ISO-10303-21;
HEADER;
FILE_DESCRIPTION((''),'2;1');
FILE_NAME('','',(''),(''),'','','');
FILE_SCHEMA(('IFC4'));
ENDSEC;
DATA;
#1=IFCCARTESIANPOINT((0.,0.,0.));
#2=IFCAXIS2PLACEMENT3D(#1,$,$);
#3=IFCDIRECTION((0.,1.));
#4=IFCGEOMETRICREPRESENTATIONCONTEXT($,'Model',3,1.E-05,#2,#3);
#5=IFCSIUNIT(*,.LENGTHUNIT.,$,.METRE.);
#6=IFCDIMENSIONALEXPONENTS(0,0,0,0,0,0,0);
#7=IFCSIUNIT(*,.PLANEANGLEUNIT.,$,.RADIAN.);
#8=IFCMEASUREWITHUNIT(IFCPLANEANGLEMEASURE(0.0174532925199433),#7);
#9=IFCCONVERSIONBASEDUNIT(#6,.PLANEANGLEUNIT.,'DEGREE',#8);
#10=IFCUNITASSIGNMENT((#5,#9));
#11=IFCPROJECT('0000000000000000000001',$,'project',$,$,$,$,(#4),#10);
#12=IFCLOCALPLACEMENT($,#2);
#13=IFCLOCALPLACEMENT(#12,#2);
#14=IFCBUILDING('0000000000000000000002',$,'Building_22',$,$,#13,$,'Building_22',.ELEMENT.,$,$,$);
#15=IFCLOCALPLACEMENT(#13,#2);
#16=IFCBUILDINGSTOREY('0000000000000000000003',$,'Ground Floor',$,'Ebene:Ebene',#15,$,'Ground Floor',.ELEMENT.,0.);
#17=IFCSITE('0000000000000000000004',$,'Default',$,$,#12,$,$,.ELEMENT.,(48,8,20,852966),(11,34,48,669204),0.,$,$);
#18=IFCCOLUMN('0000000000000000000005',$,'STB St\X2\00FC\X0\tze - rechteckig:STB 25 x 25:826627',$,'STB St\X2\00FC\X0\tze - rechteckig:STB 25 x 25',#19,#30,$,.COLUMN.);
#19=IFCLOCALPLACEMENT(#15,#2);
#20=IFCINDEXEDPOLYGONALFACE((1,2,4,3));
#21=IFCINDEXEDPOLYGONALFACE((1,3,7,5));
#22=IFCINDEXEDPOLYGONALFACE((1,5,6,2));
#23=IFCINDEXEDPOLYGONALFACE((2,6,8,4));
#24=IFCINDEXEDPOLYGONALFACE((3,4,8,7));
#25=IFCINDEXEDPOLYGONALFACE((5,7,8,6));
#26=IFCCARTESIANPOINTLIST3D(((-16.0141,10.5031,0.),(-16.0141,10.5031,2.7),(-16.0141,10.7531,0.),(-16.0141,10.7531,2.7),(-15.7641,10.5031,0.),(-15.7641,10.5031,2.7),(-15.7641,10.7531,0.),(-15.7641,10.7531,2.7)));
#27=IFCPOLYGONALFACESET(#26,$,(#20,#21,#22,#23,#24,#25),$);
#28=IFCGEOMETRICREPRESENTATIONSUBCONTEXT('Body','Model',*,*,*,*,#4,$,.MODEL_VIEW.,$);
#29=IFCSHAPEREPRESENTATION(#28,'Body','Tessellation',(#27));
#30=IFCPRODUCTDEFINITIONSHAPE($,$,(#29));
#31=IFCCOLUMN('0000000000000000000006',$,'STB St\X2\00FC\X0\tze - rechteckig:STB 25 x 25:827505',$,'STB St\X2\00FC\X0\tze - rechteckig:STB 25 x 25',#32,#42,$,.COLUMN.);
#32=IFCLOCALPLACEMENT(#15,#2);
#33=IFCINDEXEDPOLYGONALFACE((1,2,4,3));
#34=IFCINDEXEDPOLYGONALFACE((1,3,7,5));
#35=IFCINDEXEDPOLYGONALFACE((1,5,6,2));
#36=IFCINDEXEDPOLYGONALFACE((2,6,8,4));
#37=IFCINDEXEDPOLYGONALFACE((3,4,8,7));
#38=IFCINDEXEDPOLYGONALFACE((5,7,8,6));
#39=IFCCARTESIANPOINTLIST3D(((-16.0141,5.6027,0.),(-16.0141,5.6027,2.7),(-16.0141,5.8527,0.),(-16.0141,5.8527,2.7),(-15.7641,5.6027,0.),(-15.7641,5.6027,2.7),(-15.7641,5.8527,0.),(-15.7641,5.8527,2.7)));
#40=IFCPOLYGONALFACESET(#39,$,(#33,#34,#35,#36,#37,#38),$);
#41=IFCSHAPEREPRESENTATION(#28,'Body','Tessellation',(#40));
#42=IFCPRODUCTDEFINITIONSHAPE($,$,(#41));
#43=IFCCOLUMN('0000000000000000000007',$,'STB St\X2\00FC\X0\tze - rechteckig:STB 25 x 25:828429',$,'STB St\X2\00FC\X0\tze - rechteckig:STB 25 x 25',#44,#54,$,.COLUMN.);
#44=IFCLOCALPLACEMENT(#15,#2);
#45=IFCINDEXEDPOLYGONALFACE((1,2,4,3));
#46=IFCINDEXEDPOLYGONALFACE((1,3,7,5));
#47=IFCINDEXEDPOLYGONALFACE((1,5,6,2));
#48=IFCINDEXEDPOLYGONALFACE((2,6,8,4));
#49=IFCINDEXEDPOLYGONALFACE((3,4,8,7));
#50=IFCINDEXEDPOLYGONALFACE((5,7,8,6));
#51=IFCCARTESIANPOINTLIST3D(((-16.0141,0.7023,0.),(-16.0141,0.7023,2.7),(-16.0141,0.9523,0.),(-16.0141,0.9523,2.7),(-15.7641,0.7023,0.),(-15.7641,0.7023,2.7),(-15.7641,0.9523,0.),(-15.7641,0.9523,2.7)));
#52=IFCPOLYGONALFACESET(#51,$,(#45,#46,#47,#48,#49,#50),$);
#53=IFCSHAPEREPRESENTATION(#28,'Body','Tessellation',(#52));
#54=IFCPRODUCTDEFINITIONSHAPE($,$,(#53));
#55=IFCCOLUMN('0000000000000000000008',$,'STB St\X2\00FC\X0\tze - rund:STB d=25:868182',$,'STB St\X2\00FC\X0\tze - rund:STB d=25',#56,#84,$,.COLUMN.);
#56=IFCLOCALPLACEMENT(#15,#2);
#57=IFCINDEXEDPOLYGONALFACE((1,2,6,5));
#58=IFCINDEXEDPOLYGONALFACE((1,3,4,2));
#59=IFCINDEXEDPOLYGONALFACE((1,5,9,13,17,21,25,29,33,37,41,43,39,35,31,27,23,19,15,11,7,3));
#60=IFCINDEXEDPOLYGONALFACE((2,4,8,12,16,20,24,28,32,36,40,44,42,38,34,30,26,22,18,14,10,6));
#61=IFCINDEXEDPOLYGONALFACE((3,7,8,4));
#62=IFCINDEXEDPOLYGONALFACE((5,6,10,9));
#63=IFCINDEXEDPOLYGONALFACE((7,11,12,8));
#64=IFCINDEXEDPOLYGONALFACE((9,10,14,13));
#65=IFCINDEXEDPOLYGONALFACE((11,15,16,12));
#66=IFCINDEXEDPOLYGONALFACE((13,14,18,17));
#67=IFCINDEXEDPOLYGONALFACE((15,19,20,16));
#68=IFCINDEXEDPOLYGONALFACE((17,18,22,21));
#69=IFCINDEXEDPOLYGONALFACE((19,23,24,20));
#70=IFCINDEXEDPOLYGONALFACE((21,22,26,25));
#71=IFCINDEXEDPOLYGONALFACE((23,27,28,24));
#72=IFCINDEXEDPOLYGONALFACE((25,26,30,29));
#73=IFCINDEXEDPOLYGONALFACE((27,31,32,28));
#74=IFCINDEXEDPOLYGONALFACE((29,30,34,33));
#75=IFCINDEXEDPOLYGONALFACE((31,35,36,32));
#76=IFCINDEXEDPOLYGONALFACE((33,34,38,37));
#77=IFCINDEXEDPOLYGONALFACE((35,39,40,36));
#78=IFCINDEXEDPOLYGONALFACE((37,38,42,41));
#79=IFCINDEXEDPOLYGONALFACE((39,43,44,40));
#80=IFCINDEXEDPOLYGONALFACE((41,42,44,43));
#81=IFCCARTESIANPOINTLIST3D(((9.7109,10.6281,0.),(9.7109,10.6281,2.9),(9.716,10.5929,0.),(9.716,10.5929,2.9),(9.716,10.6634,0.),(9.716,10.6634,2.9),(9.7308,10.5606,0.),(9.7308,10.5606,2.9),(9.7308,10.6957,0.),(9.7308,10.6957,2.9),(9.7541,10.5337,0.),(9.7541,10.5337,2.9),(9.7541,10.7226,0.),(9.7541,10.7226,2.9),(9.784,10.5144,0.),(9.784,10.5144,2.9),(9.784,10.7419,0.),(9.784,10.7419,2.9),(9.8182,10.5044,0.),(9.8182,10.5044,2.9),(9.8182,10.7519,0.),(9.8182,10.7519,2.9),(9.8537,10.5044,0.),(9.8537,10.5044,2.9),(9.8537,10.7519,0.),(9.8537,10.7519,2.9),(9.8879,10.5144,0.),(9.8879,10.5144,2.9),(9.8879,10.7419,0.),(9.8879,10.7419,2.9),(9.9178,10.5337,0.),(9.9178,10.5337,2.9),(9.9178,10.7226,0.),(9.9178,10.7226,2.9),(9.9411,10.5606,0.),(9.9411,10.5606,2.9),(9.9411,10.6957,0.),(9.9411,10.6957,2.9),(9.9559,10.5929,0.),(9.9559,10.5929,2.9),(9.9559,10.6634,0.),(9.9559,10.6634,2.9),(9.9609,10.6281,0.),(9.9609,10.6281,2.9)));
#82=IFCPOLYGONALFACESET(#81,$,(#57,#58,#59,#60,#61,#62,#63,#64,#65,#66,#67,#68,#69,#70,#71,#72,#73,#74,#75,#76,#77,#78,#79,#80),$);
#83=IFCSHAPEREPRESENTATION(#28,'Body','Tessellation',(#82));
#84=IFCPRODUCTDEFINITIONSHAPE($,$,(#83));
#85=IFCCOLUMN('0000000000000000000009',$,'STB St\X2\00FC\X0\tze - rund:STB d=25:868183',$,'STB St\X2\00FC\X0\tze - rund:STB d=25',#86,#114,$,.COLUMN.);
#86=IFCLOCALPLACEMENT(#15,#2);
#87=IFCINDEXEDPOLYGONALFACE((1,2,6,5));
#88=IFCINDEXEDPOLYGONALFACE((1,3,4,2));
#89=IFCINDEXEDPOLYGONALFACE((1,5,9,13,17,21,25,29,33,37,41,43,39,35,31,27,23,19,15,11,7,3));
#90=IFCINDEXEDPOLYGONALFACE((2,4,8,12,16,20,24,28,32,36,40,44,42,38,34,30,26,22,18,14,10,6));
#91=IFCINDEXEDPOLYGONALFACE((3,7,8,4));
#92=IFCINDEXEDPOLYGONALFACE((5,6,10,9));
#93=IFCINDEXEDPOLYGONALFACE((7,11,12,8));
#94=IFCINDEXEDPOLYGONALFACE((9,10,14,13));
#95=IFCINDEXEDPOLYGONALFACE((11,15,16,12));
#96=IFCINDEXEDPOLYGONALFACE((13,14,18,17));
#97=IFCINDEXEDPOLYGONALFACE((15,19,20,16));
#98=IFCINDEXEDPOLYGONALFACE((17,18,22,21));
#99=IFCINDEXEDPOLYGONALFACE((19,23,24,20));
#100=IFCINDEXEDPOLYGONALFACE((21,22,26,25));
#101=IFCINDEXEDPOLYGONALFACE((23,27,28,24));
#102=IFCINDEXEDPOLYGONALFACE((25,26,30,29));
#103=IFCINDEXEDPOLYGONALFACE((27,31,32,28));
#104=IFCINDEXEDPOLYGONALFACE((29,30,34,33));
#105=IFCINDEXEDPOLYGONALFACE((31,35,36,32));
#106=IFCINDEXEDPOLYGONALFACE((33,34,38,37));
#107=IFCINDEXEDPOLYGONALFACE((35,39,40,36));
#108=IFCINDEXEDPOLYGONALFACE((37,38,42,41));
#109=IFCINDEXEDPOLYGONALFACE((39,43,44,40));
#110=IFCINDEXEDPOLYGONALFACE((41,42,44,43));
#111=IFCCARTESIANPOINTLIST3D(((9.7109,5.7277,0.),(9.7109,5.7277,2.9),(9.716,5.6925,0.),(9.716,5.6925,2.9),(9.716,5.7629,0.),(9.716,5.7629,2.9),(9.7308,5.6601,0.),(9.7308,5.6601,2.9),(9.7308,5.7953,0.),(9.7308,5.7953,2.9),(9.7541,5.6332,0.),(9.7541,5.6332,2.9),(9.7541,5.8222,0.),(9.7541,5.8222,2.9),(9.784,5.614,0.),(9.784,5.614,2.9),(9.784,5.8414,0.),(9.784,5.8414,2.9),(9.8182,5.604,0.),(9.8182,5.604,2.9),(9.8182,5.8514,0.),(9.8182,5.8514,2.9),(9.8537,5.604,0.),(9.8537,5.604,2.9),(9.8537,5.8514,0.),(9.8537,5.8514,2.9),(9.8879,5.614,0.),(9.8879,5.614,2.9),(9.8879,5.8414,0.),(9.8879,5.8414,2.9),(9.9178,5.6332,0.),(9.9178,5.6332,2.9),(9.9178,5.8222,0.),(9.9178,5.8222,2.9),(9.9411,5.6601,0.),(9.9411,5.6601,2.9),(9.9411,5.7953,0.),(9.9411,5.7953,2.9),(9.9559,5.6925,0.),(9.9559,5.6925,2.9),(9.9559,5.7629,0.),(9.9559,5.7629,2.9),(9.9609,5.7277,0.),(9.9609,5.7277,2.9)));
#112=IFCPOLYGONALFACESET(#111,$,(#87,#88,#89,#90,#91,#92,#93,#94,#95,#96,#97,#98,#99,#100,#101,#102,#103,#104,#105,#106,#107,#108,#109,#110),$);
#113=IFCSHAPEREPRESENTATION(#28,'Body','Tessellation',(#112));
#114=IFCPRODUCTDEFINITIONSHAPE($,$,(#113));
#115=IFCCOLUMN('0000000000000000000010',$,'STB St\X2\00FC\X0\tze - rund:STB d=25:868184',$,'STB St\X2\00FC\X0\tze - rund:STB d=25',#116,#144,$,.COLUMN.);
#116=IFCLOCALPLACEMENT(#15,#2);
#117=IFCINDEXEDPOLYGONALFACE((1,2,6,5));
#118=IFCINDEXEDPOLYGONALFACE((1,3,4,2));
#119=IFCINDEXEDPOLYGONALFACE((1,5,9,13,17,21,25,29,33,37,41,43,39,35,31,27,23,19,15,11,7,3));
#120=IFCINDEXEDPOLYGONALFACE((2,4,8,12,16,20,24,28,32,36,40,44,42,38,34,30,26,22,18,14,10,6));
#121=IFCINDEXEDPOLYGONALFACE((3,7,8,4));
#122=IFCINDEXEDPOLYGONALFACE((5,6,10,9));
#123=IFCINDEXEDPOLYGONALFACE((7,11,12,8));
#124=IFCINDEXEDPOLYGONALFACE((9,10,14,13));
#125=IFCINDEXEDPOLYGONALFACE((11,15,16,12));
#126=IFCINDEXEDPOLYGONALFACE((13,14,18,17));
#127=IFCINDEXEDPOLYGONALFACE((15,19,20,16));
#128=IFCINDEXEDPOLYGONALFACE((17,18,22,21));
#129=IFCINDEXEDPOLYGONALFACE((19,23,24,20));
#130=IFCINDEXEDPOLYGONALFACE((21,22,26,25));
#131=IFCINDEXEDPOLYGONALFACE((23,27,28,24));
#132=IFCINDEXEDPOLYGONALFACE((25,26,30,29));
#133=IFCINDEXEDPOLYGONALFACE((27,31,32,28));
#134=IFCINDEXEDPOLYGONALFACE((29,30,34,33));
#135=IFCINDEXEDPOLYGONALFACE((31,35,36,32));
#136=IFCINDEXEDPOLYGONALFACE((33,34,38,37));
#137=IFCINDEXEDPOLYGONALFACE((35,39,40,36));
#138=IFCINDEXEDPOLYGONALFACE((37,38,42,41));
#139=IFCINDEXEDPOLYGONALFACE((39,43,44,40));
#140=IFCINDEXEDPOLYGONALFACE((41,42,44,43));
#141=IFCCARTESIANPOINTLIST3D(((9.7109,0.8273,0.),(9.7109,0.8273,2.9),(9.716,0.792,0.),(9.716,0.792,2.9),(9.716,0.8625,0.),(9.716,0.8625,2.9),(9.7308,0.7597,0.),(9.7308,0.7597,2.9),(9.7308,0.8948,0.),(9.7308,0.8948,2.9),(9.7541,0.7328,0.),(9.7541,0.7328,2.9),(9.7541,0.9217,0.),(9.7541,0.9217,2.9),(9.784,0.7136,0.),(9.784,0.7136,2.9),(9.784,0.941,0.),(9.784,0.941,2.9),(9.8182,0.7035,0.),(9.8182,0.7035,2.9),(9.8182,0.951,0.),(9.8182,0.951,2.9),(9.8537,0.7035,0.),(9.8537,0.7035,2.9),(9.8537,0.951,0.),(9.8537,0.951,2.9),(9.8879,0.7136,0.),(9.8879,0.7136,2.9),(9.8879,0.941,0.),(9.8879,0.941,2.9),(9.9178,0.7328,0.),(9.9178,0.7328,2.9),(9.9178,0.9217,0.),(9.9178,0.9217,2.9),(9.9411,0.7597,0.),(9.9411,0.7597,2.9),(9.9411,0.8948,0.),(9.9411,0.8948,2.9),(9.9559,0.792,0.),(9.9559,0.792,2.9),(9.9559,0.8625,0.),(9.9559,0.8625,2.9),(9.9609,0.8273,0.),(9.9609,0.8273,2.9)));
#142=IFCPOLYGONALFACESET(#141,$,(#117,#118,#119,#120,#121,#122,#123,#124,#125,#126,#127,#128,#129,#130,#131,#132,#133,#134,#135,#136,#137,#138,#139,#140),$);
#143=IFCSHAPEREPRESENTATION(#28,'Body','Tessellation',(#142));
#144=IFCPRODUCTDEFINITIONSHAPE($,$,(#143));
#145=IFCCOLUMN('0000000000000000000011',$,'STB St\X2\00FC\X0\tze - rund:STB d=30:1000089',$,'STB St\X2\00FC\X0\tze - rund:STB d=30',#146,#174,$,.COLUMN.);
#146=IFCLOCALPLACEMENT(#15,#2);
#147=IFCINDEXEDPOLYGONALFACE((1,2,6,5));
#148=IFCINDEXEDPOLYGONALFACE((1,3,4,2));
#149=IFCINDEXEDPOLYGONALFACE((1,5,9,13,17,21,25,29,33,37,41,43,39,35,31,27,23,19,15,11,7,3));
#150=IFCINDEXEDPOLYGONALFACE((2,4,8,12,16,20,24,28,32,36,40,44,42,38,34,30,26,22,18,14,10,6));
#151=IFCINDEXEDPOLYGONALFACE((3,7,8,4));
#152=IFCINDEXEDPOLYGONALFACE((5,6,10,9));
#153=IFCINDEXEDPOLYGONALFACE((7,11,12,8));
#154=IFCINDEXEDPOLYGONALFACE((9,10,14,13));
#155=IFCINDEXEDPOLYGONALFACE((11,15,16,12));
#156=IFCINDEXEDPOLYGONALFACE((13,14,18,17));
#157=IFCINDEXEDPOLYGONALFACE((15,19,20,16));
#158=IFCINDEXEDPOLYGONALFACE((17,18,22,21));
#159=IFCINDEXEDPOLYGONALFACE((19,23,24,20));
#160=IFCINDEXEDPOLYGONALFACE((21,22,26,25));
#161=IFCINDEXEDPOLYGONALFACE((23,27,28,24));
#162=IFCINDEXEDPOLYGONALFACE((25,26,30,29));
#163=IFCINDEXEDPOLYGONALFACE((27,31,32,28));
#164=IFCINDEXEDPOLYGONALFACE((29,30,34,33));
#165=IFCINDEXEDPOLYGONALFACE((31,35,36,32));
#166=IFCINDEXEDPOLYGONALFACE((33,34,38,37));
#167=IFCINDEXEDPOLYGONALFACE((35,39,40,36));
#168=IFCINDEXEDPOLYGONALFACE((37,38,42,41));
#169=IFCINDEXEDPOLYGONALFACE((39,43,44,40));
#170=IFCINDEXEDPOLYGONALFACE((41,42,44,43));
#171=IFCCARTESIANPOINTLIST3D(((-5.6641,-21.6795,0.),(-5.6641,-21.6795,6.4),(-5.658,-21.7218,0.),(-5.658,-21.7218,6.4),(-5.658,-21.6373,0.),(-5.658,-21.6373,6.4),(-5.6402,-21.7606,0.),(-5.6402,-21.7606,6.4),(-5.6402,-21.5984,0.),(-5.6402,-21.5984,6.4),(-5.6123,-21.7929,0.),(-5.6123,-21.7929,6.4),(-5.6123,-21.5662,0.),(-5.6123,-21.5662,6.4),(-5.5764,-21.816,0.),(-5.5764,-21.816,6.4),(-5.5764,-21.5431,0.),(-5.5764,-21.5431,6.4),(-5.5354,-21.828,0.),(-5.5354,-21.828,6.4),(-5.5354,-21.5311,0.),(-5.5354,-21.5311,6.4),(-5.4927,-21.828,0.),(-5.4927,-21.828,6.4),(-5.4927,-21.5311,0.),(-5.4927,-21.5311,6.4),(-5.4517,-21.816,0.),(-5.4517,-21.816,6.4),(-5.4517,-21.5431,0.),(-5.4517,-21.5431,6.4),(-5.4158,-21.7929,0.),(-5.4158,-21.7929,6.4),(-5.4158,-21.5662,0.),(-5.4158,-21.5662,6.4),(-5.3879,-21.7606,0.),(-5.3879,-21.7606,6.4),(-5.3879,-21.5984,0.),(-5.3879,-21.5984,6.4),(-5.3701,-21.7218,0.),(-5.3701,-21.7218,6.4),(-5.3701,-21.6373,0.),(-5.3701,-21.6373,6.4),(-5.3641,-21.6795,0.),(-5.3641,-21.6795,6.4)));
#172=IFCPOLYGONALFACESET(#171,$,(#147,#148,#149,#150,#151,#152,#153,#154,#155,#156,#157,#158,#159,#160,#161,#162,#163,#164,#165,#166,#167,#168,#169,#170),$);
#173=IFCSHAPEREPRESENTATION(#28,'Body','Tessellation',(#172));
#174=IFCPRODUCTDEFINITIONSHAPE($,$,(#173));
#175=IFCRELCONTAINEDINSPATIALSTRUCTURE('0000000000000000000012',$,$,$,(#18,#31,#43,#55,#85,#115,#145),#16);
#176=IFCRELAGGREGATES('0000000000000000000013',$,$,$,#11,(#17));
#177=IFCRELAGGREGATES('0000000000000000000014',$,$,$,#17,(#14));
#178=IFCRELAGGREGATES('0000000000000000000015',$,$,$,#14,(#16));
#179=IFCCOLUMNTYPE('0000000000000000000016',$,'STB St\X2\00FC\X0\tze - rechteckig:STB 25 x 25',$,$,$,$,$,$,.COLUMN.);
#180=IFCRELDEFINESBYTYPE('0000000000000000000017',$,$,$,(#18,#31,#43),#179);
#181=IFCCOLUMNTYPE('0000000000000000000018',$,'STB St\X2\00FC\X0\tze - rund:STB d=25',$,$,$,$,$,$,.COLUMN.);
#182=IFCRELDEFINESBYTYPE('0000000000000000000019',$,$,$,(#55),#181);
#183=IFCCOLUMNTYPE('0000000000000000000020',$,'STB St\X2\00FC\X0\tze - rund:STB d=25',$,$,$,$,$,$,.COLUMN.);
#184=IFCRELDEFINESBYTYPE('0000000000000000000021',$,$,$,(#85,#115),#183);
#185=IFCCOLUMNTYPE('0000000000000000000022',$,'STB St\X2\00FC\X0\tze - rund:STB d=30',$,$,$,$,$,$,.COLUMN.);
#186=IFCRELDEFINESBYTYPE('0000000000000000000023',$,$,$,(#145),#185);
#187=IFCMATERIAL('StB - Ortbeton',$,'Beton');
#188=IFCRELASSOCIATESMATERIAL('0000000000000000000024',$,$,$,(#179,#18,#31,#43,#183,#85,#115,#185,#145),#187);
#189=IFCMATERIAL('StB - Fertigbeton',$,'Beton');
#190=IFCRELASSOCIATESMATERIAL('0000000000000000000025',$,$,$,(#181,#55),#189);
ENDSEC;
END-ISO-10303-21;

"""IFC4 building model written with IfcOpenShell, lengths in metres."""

from ifc_helpers import new_model, entity, si_unit, converted_unit, direction, frame, origin, place, context, subcontext, project, spatial, arc, indexed_curve, outline, extrude, source, transform, mapped, material, type_object, type_shapes, element, save


model = new_model("IFC4")

# Units and contexts
model_context = context("Model", 3, precision=1e-05, world=origin(), true_north=direction((0.0, 1.0)))
body_context = subcontext(model_context, "Body", "Model", "MODEL_VIEW")
ifc_project = project(units=[si_unit("LENGTHUNIT", "METRE"), converted_unit("PLANEANGLEUNIT", "DEGREE", entity("IfcPlaneAngleMeasure", 0.0174532925199433), si_unit("PLANEANGLEUNIT", "RADIAN"), dimensions=[0, 0, 0, 0, 0, 0, 0])], contexts=[model_context])

# Site, building, storey
site_placement = place(None, origin())
site = spatial("IfcSite", under=ifc_project, at=site_placement, Name="Default", CompositionType="ELEMENT", RefLatitude=(48, 8, 20, 852966), RefLongitude=(11, 34, 48, 669204), RefElevation=0.0)
building_placement = place(site_placement, origin())
building = spatial("IfcBuilding", under=site, at=building_placement, Name="Building_22", LongName="Building_22", CompositionType="ELEMENT")
storey_placement = place(building_placement, origin())
storey = spatial("IfcBuildingStorey", under=building, at=storey_placement, Name="Ground Floor", ObjectType="Ebene:Ebene", LongName="Ground Floor", CompositionType="ELEMENT", Elevation=0.0)

# Columns
ifc_material_1 = material(Name="StB - Ortbeton", Category="Beton")
column_type_1 = type_object("IfcColumnType", Name="STB Stütze - rechteckig:STB 25 x 25", PredefinedType="COLUMN", material=ifc_material_1)
shared_shape_1 = source(origin(), body_context, "Body", "SweptSolid", [
    extrude(outline(indexed_curve([(-0.125, -0.125), (0.125, -0.125), (0.125, 0.125), (-0.125, 0.125), (-0.125, -0.125)], self_intersect=False)), frame((0.0, 0.0, 0.0), z_axis=(0.0, 0.0, 1.0), x_axis=(-1.0, 0.0, 0.0)), (0.0, 0.0, 1.0), 2.7),
])
type_shapes(column_type_1, [shared_shape_1])
for number, where, name in (
    (1, (-15.8891, 10.6281, 0.0), "STB Stütze - rechteckig:STB 25 x 25:826627"),
    (2, (-15.8891, 5.7277, 0.0), "STB Stütze - rechteckig:STB 25 x 25:827505"),
    (3, (-15.8891, 0.8273, 0.0), "STB Stütze - rechteckig:STB 25 x 25:828429"),
):
    element("IfcColumn", number, at=place(storey_placement, frame(where)), inside=storey, type_object=column_type_1, material=ifc_material_1, Name=name, ObjectType="STB Stütze - rechteckig:STB 25 x 25", PredefinedType="COLUMN", context=body_context, shape_type="MappedRepresentation", body=[
        mapped(shared_shape_1, transform((0.0, 0.0, 0.0), scale=1.0)),
    ])
ifc_material_2 = material(Name="StB - Fertigbeton", Category="Beton")
column_type_2 = type_object("IfcColumnType", Name="STB Stütze - rund:STB d=25", PredefinedType="COLUMN", material=ifc_material_2)
shared_shape_2 = source(origin(), body_context, "Body", "SweptSolid", [
    extrude(outline(indexed_curve([(-0.125, 0.0), (0.0, -0.125), (0.125, 0.0), (0.0, 0.125)], segments=[arc(1, 2, 3), arc(3, 4, 1)], self_intersect=False)), origin(), (0.0, 0.0, 1.0), 2.9),
])
type_shapes(column_type_2, [shared_shape_2])
column_1_placement = place(storey_placement, frame((9.8359, 10.6281, 0.0), z_axis=(0.0, 0.0, 1.0), x_axis=(-1.0, 0.0, 0.0)))
element("IfcColumn", 4, at=column_1_placement, inside=storey, type_object=column_type_2, material=ifc_material_2, Name="STB Stütze - rund:STB d=25:868182", ObjectType="STB Stütze - rund:STB d=25", PredefinedType="COLUMN", context=body_context, shape_type="MappedRepresentation", body=[
    mapped(shared_shape_2, transform((0.0, 0.0, 0.0), scale=1.0)),
])
column_type_3 = type_object("IfcColumnType", Name="STB Stütze - rund:STB d=25", PredefinedType="COLUMN", material=ifc_material_1)
shared_shape_3 = source(origin(), body_context, "Body", "SweptSolid", [
    extrude(outline(indexed_curve([(-0.125, 0.0), (0.0, -0.125), (0.125, 0.0), (0.0, 0.125)], segments=[arc(1, 2, 3), arc(3, 4, 1)], self_intersect=False)), origin(), (0.0, 0.0, 1.0), 2.9),
])
type_shapes(column_type_3, [shared_shape_3])
for number, where, z_axis, x_axis, name in (
    (5, (9.8359, 5.7277, 0.0), (0.0, 0.0, 1.0), (-1.0, 0.0, 0.0), "STB Stütze - rund:STB d=25:868183"),
    (6, (9.8359, 0.8273, 0.0), (0.0, 0.0, 1.0), (-1.0, 0.0, 0.0), "STB Stütze - rund:STB d=25:868184"),
):
    element("IfcColumn", number, at=place(storey_placement, frame(where, z_axis=z_axis, x_axis=x_axis)), inside=storey, type_object=column_type_3, material=ifc_material_1, Name=name, ObjectType="STB Stütze - rund:STB d=25", PredefinedType="COLUMN", context=body_context, shape_type="MappedRepresentation", body=[
        mapped(shared_shape_3, transform((0.0, 0.0, 0.0), scale=1.0)),
    ])
column_type_4 = type_object("IfcColumnType", Name="STB Stütze - rund:STB d=30", PredefinedType="COLUMN", material=ifc_material_1)
shared_shape_4 = source(origin(), body_context, "Body", "SweptSolid", [
    extrude(outline(indexed_curve([(-0.15, 0.0), (0.0, -0.15), (0.15, 0.0), (0.0, 0.15)], segments=[arc(1, 2, 3), arc(3, 4, 1)], self_intersect=False)), frame((-5.5141, -21.6795, 0.0)), (0.0, 0.0, 1.0), 6.4),
])
type_shapes(column_type_4, [shared_shape_4])
column_2_placement = place(storey_placement, origin())
element("IfcColumn", 7, at=column_2_placement, inside=storey, type_object=column_type_4, material=ifc_material_1, Name="STB Stütze - rund:STB d=30:1000089", ObjectType="STB Stütze - rund:STB d=30", PredefinedType="COLUMN", context=body_context, shape_type="MappedRepresentation", body=[
    mapped(shared_shape_4, transform((0.0, 0.0, 0.0), scale=1.0)),
])

save(model, "model.ifc")
